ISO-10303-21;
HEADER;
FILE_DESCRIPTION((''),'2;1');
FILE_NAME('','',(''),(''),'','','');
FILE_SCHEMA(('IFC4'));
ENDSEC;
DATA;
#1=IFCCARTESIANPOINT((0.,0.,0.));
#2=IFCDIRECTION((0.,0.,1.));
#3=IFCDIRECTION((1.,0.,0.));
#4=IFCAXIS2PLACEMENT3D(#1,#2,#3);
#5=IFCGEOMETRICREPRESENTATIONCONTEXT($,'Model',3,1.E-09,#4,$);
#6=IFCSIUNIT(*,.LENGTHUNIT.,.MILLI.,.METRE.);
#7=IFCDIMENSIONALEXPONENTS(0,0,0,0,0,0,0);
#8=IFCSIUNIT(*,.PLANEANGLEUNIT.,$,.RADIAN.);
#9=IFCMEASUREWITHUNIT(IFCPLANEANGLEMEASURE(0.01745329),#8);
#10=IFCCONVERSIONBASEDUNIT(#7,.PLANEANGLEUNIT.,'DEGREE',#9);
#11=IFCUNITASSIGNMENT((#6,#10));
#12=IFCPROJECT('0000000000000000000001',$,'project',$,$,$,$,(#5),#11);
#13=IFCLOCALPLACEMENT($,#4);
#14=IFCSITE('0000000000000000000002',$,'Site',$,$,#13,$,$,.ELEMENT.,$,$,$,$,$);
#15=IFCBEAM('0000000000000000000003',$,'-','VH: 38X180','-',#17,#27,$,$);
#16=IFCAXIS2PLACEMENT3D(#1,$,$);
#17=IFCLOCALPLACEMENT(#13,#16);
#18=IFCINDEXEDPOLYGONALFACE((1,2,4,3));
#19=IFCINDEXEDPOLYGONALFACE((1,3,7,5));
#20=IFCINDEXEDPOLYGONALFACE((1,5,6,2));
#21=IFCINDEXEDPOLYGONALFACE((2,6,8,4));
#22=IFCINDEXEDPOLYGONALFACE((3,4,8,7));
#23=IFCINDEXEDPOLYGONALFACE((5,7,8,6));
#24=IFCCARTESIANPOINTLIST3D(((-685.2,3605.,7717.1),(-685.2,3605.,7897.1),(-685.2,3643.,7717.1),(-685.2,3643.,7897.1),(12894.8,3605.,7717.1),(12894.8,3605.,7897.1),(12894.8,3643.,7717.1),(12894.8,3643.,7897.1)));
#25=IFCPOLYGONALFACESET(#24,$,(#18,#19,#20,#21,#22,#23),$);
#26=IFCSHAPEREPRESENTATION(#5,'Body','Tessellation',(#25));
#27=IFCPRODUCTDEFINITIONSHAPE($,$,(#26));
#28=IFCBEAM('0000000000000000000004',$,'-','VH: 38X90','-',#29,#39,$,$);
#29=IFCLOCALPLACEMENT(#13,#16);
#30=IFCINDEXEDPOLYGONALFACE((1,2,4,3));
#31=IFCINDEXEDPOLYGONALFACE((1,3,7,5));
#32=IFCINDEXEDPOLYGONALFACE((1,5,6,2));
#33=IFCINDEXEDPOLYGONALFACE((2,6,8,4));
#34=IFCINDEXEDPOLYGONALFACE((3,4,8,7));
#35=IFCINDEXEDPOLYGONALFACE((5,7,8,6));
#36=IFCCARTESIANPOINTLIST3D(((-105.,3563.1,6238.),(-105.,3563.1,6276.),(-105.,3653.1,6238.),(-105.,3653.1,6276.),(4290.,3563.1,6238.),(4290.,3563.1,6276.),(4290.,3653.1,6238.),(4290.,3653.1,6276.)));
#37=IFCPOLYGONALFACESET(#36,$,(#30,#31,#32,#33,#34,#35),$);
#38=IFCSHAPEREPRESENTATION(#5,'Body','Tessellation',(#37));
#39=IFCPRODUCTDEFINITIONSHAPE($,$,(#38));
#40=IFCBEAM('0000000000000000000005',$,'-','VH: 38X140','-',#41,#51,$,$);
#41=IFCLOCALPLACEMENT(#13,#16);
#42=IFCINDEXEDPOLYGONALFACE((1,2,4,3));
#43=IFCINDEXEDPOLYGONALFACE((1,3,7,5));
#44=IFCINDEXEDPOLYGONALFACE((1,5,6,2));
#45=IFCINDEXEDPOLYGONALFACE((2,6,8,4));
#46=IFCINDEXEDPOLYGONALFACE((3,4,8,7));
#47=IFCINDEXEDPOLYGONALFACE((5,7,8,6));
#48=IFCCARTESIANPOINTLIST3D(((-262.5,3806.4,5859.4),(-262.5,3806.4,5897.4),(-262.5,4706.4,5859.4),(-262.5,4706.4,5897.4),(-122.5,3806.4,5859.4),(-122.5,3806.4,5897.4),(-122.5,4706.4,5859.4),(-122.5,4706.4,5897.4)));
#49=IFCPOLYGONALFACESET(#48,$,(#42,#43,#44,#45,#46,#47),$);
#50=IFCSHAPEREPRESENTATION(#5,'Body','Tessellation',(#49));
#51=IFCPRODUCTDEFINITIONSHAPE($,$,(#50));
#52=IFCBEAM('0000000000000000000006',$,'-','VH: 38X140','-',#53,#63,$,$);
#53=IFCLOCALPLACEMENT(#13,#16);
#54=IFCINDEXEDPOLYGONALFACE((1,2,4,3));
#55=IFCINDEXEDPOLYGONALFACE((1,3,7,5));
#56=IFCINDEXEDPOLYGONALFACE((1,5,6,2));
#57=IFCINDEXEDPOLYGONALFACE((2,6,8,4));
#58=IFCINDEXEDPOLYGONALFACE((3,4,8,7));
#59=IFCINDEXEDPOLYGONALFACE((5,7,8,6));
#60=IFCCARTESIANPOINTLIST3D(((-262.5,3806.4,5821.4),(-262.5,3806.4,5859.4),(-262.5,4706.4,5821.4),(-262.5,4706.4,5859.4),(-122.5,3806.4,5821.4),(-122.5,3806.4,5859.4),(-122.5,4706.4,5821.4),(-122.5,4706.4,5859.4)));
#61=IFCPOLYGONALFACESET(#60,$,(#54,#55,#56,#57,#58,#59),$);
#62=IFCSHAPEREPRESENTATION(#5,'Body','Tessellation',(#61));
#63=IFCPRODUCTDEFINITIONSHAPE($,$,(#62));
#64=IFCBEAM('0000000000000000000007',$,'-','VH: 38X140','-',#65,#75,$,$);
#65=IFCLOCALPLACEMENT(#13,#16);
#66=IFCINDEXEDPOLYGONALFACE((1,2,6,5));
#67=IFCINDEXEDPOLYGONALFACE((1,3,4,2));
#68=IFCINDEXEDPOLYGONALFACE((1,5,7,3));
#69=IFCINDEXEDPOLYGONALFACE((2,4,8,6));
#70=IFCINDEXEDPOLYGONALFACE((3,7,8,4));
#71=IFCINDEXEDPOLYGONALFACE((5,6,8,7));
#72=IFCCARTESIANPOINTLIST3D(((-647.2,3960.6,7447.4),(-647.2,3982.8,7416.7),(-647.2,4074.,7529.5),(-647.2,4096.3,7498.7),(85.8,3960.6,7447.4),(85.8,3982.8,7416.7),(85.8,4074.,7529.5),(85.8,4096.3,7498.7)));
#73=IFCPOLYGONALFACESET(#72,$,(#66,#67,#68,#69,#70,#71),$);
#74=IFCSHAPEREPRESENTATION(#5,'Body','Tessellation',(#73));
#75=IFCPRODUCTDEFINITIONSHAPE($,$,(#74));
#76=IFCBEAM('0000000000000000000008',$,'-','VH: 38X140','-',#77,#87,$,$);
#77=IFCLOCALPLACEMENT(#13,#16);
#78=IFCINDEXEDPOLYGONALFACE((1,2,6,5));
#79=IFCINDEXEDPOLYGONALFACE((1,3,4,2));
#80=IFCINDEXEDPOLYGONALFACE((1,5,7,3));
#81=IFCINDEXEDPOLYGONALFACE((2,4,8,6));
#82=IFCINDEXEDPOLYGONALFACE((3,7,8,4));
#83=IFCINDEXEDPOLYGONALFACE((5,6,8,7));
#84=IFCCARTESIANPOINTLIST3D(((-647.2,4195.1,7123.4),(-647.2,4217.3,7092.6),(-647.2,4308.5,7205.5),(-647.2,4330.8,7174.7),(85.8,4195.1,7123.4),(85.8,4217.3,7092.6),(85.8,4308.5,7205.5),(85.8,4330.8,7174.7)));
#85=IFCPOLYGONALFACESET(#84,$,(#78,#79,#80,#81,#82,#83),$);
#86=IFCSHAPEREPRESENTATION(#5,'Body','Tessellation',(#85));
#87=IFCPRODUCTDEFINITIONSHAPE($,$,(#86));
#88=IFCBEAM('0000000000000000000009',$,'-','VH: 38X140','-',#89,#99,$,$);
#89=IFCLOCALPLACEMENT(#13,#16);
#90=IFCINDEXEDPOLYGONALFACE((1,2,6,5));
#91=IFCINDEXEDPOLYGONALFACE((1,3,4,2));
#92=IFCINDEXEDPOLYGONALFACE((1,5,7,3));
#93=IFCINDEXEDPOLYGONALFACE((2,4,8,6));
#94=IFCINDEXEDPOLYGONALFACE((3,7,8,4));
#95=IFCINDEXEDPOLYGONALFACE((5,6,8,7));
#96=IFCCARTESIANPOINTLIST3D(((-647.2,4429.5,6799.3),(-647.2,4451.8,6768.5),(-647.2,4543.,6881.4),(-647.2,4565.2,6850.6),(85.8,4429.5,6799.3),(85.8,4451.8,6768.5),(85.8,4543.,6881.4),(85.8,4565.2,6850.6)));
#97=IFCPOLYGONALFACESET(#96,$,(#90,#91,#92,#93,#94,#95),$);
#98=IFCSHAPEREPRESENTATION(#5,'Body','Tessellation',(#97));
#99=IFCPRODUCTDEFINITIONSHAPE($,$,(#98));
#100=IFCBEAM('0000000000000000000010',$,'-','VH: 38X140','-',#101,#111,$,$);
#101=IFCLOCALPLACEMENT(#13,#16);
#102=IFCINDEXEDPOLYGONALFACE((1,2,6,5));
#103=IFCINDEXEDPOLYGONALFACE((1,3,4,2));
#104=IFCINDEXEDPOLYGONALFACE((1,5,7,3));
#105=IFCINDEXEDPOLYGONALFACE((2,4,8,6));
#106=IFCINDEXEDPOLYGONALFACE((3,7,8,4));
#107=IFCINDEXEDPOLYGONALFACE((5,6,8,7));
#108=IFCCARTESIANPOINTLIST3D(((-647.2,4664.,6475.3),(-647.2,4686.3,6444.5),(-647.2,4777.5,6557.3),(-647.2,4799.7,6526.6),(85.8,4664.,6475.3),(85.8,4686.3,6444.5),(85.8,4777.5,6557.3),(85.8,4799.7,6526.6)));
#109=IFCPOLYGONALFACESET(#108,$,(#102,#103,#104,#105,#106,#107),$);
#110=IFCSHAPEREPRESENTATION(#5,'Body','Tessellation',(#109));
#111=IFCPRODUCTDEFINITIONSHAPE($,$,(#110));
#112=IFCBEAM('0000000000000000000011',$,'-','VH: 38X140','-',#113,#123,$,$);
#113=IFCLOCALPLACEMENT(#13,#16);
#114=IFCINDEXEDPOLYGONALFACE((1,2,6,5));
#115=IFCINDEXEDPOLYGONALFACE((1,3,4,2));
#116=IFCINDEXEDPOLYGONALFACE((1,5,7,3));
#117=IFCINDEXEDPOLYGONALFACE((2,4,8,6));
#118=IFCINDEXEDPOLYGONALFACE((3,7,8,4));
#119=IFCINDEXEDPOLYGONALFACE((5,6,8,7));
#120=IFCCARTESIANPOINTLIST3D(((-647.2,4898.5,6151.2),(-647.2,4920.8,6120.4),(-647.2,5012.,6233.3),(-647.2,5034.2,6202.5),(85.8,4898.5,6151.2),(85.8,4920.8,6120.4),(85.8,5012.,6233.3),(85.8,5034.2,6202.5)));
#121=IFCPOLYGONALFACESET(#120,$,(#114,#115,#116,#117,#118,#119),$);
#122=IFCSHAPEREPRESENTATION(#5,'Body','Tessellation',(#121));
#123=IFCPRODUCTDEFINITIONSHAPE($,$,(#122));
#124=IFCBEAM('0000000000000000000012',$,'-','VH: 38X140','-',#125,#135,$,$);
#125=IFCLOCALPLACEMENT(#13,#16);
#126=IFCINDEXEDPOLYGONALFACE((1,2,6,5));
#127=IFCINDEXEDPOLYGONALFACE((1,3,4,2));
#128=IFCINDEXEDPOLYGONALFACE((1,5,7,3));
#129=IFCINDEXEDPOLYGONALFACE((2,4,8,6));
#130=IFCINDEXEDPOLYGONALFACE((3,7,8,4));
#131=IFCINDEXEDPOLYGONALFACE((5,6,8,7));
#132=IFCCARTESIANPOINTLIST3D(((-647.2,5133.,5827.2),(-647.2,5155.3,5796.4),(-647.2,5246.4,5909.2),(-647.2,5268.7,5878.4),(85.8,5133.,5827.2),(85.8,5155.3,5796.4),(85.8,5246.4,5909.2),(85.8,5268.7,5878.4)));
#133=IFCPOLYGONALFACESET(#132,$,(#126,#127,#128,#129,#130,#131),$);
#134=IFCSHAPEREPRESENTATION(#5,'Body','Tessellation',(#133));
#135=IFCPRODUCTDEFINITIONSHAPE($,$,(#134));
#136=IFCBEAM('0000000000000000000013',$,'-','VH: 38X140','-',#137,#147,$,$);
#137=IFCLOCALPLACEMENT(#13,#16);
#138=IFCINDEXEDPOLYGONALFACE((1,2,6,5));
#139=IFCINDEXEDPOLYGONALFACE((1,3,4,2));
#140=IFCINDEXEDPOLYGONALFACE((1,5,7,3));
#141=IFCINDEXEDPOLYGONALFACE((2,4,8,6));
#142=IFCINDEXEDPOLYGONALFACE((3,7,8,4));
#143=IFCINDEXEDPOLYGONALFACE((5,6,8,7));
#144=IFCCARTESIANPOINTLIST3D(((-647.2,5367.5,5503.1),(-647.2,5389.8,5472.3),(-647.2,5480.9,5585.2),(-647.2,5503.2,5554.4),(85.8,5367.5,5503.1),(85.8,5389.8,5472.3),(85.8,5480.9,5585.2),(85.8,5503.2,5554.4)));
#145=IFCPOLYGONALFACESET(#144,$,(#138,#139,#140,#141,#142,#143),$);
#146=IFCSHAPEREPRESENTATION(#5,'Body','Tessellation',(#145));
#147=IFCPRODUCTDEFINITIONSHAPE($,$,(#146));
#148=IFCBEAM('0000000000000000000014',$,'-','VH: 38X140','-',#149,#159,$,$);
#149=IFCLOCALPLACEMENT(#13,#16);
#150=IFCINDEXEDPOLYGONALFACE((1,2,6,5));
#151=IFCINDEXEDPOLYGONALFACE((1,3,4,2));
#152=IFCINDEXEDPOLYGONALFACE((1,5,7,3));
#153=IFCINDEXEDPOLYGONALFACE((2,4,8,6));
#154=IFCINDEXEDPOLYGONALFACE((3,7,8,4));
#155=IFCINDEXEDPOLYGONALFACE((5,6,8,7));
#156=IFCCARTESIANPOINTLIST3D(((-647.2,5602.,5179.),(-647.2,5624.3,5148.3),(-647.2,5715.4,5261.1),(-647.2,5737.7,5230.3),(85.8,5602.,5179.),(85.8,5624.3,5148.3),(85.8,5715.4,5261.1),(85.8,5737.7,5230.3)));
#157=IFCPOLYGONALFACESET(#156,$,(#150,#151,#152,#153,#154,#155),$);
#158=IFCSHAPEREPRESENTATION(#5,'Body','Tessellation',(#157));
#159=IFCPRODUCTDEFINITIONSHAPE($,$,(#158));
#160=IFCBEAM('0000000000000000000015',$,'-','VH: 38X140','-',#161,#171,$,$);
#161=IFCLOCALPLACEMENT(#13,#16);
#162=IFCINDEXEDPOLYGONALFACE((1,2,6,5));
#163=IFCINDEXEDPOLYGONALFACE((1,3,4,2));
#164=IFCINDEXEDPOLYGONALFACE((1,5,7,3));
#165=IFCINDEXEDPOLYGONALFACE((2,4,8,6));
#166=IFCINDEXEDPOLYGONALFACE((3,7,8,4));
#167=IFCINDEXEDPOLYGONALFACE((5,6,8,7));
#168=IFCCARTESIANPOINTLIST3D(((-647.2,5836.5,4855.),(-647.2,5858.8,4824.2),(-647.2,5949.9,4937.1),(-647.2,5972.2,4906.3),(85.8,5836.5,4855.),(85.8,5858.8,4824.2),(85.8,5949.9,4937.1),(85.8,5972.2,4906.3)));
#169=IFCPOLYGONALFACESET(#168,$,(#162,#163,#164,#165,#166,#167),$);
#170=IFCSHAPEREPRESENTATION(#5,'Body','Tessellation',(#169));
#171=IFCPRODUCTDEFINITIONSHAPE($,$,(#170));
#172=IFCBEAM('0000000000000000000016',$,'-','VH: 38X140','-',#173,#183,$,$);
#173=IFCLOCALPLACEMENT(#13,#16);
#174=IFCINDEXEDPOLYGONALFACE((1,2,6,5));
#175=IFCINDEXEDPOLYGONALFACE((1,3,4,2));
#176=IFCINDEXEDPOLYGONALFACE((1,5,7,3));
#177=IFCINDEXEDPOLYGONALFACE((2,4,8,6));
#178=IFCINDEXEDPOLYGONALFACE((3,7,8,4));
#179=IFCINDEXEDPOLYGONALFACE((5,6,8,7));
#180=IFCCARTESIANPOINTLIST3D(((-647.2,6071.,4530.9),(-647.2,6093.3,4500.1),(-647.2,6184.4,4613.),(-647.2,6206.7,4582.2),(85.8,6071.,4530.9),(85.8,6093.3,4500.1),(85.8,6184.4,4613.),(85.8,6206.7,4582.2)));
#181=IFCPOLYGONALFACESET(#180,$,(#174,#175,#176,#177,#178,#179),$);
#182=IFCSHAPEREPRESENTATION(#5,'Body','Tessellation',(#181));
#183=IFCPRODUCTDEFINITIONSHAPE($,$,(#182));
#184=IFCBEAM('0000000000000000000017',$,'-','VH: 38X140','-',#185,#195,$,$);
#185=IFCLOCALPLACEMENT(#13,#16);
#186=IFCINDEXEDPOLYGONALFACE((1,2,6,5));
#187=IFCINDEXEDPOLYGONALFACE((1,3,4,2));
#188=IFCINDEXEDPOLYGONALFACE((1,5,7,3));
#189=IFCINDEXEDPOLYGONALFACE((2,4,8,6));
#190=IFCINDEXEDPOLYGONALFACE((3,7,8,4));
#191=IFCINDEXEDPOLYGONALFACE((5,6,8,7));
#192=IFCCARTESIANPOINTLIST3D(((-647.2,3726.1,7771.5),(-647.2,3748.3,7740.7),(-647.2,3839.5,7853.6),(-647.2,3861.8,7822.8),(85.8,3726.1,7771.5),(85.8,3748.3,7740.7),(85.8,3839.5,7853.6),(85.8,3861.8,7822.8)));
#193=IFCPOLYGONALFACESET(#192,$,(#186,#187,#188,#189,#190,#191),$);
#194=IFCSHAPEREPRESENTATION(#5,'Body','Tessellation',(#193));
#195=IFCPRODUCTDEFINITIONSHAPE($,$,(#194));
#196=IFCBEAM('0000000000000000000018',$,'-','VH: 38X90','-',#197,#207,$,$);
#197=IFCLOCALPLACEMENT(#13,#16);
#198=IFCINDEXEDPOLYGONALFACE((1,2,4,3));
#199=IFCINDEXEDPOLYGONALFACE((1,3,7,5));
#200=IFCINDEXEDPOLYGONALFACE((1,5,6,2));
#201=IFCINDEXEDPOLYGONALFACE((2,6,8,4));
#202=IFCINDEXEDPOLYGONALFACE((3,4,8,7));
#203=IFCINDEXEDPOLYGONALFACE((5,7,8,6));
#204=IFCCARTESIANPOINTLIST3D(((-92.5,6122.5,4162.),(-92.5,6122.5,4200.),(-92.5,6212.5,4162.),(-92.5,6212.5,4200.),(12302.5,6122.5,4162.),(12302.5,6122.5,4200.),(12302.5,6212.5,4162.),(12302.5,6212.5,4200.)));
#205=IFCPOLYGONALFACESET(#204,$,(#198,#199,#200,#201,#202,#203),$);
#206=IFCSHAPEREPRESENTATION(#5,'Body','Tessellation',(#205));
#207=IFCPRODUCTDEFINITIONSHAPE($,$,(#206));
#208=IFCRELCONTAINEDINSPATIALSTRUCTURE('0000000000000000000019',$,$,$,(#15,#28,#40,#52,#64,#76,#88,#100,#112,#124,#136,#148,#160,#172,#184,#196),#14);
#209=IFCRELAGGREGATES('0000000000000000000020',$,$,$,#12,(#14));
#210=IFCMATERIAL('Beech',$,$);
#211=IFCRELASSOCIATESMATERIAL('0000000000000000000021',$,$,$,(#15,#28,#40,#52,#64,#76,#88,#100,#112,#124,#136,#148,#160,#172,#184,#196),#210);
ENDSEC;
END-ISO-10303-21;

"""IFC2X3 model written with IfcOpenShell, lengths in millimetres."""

from ifc_helpers import new_model, entity, si_unit, converted_unit, frame, origin, origin_with_axes, origin_2d, place, context, project, spatial, rectangle, extrude, material, element, save


model = new_model("IFC2X3")

# Units and contexts
model_context = context("Model", 3, precision=1e-09, world=origin_with_axes())
ifc_project = project(units=[si_unit("LENGTHUNIT", "METRE", prefix="MILLI"), converted_unit("PLANEANGLEUNIT", "DEGREE", entity("IfcPlaneAngleMeasure", 0.01745329), si_unit("PLANEANGLEUNIT", "RADIAN"), dimensions=[0, 0, 0, 0, 0, 0, 0])], contexts=[model_context])

# Site
site_placement = place(None, origin_with_axes())
site = spatial("IfcSite", under=ifc_project, at=site_placement, Name="Site", CompositionType="ELEMENT")

# Shared definitions
ifc_material = material(Name="Beech")

# Beams
beam_1_placement = place(None, frame((-685.2, 3624.0, 7807.1), z_axis=(-1.0, 0.0, 0.0), x_axis=(0.0, -1.0, 0.0)))
element("IfcBeam", 1, at=beam_1_placement, inside=site, material=ifc_material, Name="-", Description="VH: 38X180", ObjectType="-", context=model_context, shape_type="SweptSolid", body=[
    extrude(rectangle(XDim=38.0, YDim=180.0, at=origin_2d()), origin(), (0.0, 0.0, -1.0), 13580.0),
])
beam_2_placement = place(None, frame((-105.0, 3608.1, 6257.0), z_axis=(-1.0, 0.0, 0.0), x_axis=(0.0, 0.0, -1.0)))
element("IfcBeam", 2, at=beam_2_placement, inside=site, material=ifc_material, Name="-", Description="VH: 38X90", ObjectType="-", context=model_context, shape_type="SweptSolid", body=[
    extrude(rectangle(XDim=38.0, YDim=90.0, at=origin_2d()), origin(), (0.0, 0.0, -1.0), 4395.0),
])

# Beams
for number, where, z_axis, x_axis, name in (
    (3, (-192.5, 4706.4, 5878.4), (0.0, 1.0, 0.0), (0.0, 0.0, -1.0), "-"),
    (4, (-192.5, 4706.4, 5840.4), (0.0, 1.0, 0.0), (0.0, 0.0, -1.0), "-"),
):
    element("IfcBeam", number, at=place(None, frame(where, z_axis=z_axis, x_axis=x_axis)), inside=site, material=ifc_material, Name=name, Description="VH: 38X140", ObjectType="-", context=model_context, shape_type="SweptSolid", body=[
        extrude(rectangle(XDim=38.0, YDim=140.0, at=origin_2d()), origin(), (0.0, 0.0, -1.0), 900.0),
    ])
for number, where, z_axis, x_axis, name in (
    (5, (-647.2, 4028.4, 7473.1), (-1.0, 0.0, 0.0), (0.0, -0.58623, 0.810145), "-"),
    (6, (-647.2, 4262.9, 7149.0), (-1.0, 0.0, 0.0), (0.0, -0.58623, 0.810145), "-"),
    (7, (-647.2, 4497.4, 6825.0), (-1.0, 0.0, 0.0), (0.0, -0.58623, 0.810145), "-"),
    (8, (-647.2, 4731.9, 6500.9), (-1.0, 0.0, 0.0), (0.0, -0.58623, 0.810145), "-"),
    (9, (-647.2, 4966.4, 6176.9), (-1.0, 0.0, 0.0), (0.0, -0.58623, 0.810145), "-"),
    (10, (-647.2, 5200.9, 5852.8), (-1.0, 0.0, 0.0), (0.0, -0.58623, 0.810145), "-"),
    (11, (-647.2, 5435.4, 5528.7), (-1.0, 0.0, 0.0), (0.0, -0.58623, 0.810145), "-"),
    (12, (-647.2, 5669.9, 5204.7), (-1.0, 0.0, 0.0), (0.0, -0.58623, 0.810145), "-"),
    (13, (-647.2, 5904.3, 4880.6), (-1.0, 0.0, 0.0), (0.0, -0.58623, 0.810145), "-"),
    (14, (-647.2, 6138.8, 4556.6), (-1.0, 0.0, 0.0), (0.0, -0.58623, 0.810145), "-"),
    (15, (-647.2, 3793.9, 7797.2), (-1.0, 0.0, 0.0), (0.0, -0.58623, 0.810145), "-"),
):
    element("IfcBeam", number, at=place(None, frame(where, z_axis=z_axis, x_axis=x_axis)), inside=site, material=ifc_material, Name=name, Description="VH: 38X140", ObjectType="-", context=model_context, shape_type="SweptSolid", body=[
        extrude(rectangle(XDim=38.0, YDim=140.0, at=origin_2d()), origin(), (0.0, 0.0, -1.0), 733.0),
    ])
beam_3_placement = place(None, frame((-92.5, 6167.5, 4181.0), z_axis=(-1.0, 0.0, 0.0), x_axis=(0.0, 0.0, 1.0)))
element("IfcBeam", 16, at=beam_3_placement, inside=site, material=ifc_material, Name="-", Description="VH: 38X90", ObjectType="-", context=model_context, shape_type="SweptSolid", body=[
    extrude(rectangle(XDim=38.0, YDim=90.0, at=origin_2d()), origin(), (0.0, 0.0, -1.0), 12395.0),
])

save(model, "model.ifc")
